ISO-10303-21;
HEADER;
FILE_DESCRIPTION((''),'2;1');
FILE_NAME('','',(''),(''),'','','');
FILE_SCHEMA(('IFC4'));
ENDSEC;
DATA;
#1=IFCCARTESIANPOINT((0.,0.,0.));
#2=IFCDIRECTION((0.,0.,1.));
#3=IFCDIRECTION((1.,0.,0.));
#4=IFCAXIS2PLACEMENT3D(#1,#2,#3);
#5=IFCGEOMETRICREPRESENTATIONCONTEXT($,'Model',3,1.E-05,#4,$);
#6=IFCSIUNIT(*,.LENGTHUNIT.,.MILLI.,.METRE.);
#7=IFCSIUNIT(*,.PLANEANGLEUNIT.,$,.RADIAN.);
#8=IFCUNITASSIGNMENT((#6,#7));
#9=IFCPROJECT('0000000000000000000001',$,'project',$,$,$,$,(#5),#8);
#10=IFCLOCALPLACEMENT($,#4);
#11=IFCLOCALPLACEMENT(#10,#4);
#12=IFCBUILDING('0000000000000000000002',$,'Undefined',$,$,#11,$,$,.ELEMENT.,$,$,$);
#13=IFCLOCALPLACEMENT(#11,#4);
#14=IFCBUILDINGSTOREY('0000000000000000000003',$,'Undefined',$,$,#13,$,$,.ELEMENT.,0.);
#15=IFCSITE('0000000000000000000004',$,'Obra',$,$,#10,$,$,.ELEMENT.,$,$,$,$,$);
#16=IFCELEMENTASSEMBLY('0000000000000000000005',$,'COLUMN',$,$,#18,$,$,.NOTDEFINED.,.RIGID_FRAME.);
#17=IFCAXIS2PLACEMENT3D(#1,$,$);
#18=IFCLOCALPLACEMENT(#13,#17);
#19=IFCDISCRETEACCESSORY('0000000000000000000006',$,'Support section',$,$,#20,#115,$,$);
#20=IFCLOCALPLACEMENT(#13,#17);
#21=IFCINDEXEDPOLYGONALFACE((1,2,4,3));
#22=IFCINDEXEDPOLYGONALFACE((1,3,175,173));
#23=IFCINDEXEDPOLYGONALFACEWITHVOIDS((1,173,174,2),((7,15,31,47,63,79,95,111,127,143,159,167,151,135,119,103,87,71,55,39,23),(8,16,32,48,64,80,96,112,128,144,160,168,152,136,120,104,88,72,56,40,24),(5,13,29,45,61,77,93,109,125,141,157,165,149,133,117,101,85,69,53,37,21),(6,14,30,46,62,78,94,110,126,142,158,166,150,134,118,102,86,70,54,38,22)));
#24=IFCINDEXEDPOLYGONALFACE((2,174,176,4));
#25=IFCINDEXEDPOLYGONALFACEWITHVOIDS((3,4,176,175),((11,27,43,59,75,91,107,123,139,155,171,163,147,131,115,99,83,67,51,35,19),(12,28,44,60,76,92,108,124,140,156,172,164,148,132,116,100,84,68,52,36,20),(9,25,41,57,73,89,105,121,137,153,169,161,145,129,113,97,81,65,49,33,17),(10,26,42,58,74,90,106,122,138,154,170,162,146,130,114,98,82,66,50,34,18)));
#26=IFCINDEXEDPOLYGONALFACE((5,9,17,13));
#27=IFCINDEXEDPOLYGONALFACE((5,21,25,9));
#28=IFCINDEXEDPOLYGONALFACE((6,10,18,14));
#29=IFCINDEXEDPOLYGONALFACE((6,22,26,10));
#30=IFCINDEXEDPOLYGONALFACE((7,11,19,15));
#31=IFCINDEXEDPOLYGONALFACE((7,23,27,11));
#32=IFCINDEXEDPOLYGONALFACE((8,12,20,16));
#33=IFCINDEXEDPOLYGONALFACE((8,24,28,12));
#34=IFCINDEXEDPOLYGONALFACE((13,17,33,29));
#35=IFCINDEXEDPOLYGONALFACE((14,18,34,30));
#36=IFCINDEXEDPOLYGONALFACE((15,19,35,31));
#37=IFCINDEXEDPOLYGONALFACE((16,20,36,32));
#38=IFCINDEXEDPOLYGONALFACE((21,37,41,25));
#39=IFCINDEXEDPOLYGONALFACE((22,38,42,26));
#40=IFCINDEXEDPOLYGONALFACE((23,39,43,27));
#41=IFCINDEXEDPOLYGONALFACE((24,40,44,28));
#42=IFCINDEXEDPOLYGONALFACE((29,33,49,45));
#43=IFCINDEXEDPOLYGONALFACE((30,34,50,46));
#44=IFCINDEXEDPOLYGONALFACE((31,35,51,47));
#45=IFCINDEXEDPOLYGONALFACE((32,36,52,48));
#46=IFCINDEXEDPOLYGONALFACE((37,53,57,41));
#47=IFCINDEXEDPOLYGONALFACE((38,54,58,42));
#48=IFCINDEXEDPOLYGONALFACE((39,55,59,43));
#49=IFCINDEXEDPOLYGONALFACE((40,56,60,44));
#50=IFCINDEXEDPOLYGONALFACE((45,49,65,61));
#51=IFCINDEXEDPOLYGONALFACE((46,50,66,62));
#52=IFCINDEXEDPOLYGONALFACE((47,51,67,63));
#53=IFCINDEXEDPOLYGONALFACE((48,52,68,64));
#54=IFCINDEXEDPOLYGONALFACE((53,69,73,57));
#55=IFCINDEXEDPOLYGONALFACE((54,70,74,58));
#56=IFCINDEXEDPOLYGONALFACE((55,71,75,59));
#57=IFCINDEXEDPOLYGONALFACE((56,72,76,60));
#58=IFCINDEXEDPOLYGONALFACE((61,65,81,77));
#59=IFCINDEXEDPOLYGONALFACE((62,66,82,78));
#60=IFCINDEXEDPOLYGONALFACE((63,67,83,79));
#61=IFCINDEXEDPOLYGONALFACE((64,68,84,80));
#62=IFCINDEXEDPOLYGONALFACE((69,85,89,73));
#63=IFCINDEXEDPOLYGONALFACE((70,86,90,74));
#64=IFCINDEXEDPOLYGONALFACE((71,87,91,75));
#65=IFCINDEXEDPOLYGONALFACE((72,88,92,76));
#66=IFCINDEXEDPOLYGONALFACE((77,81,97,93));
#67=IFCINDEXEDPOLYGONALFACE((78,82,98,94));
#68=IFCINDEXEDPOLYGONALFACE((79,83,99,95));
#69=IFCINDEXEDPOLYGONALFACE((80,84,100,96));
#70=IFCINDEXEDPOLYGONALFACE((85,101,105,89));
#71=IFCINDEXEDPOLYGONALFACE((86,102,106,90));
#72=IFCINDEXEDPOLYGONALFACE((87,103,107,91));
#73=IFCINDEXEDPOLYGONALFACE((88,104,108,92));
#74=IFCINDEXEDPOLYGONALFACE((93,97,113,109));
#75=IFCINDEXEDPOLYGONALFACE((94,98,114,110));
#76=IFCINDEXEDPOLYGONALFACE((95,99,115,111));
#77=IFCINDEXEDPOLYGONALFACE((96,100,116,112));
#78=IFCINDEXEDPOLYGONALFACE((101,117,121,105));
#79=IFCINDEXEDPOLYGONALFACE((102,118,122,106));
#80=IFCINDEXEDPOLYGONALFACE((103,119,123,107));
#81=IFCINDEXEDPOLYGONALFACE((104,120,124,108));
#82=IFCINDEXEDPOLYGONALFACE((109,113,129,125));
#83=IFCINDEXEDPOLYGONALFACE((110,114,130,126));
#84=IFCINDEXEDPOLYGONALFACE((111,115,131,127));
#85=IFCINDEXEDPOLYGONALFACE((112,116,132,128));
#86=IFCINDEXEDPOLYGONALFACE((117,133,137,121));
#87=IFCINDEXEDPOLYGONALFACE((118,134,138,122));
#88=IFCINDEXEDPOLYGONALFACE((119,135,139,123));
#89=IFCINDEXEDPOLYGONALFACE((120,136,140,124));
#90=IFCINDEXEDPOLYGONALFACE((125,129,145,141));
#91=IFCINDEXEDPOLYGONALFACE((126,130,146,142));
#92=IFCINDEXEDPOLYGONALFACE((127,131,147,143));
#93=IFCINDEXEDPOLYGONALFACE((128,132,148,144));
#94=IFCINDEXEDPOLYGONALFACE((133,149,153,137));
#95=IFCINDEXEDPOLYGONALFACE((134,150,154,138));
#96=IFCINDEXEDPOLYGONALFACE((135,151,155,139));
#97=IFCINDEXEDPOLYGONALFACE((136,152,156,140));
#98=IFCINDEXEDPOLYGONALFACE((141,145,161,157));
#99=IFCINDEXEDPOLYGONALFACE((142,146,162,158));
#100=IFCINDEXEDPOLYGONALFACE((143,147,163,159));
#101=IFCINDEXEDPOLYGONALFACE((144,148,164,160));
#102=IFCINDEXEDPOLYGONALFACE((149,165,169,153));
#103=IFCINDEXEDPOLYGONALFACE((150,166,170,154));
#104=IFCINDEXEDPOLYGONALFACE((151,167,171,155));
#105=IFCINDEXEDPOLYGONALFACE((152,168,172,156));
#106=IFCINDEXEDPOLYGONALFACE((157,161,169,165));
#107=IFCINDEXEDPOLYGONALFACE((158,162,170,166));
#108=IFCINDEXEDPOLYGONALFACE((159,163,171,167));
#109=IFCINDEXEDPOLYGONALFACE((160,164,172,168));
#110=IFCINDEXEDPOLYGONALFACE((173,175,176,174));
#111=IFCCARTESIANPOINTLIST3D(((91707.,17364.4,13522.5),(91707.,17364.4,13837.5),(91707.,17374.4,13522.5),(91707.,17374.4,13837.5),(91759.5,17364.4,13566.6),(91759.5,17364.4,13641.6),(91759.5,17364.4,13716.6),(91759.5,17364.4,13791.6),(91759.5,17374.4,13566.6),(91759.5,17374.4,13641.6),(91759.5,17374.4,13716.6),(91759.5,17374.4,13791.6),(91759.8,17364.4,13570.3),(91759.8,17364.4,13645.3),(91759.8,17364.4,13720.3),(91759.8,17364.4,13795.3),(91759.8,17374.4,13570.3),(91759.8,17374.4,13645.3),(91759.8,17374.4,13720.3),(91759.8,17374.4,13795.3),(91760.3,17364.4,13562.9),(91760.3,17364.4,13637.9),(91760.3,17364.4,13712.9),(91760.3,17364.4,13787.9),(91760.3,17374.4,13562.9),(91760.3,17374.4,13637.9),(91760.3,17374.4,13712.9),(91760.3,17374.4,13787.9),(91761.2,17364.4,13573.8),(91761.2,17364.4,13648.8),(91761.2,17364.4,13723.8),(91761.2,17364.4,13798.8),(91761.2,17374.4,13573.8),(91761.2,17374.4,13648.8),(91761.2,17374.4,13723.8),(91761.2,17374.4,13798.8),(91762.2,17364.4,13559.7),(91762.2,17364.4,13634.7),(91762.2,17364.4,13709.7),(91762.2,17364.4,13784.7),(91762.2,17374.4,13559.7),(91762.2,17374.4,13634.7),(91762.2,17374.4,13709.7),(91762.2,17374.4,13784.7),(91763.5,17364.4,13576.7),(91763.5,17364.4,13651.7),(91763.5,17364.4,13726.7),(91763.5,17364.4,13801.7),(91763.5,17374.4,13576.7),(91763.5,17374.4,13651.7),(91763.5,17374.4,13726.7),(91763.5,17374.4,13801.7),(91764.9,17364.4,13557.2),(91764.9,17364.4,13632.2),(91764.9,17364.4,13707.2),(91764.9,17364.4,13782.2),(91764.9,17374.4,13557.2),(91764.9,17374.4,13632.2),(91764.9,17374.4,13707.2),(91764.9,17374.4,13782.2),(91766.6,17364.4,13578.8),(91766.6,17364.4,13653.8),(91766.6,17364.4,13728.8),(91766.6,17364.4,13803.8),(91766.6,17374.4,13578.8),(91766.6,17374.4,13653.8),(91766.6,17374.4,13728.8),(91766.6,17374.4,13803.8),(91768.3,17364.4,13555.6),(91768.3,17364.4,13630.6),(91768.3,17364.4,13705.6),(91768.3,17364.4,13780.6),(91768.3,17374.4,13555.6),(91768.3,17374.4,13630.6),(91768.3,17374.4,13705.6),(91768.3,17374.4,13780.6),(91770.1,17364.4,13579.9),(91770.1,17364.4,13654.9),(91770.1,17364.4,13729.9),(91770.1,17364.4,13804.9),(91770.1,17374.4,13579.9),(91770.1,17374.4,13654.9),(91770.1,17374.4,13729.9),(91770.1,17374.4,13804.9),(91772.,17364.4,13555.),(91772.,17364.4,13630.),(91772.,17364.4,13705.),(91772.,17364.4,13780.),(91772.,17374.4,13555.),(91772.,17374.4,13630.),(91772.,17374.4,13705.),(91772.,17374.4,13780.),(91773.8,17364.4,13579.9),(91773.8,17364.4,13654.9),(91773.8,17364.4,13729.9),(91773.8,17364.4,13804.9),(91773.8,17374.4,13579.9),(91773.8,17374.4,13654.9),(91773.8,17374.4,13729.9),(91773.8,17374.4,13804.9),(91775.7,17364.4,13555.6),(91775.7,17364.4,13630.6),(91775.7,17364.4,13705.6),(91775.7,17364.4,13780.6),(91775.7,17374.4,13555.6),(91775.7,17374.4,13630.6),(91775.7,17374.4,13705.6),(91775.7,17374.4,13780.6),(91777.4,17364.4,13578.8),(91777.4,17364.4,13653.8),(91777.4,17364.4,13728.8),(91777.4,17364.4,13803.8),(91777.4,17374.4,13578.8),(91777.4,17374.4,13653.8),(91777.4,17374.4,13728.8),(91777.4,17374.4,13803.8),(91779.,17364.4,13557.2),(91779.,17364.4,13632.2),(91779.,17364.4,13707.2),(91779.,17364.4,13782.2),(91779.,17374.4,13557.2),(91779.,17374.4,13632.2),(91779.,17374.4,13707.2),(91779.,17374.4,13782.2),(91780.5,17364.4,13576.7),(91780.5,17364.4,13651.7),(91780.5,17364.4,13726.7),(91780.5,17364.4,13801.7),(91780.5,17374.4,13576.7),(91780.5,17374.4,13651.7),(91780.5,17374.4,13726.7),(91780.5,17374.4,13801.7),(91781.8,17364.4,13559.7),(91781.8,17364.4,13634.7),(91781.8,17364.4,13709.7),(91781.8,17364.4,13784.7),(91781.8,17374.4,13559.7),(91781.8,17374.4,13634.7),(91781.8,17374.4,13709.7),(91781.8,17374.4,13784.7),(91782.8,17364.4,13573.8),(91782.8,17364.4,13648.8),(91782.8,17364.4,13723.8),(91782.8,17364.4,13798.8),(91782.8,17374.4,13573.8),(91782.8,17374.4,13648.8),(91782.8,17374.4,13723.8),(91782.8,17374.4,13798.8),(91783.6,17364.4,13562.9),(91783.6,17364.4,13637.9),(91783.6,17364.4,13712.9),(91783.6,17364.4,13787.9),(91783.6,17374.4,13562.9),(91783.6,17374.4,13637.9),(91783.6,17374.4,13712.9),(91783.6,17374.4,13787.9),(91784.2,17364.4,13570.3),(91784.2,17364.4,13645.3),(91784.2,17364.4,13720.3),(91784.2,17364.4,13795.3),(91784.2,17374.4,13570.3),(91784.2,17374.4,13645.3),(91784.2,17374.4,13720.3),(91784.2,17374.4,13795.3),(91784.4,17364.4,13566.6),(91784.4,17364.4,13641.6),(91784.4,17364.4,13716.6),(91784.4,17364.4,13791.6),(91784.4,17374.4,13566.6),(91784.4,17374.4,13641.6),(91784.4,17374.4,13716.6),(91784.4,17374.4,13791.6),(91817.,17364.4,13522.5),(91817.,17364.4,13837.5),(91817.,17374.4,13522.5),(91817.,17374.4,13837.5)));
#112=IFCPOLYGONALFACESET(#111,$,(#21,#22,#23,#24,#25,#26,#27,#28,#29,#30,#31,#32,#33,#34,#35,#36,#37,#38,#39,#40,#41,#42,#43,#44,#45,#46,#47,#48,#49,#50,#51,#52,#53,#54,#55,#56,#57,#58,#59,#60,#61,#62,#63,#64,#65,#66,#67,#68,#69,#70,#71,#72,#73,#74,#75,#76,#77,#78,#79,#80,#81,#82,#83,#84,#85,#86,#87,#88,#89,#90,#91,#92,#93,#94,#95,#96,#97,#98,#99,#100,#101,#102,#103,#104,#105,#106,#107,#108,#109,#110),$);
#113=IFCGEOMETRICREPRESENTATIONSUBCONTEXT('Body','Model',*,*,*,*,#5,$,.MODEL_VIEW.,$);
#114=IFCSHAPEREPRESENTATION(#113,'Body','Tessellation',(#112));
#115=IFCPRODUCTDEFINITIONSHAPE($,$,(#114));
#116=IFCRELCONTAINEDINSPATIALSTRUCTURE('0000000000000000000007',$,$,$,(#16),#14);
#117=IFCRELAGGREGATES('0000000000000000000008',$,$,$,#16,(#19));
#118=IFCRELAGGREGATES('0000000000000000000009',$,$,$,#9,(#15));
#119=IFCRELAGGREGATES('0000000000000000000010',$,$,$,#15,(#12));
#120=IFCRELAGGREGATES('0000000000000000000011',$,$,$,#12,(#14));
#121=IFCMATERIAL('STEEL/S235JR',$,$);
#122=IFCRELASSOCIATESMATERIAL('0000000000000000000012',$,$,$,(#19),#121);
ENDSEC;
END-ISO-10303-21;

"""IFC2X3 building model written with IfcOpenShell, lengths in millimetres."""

from ifc_helpers import new_model, si_unit, frame, origin_with_axes, origin_2d_with_axis, place, context, subcontext, project, spatial, rectangle, circle, extrude, source, transform, mapped, material, element, aggregate, save


model = new_model("IFC2X3")

# Units and contexts
model_context = context("Model", 3, precision=1e-05, world=origin_with_axes())
body_context = subcontext(model_context, "Body", "Model", "MODEL_VIEW")
ifc_project = project(units=[si_unit("LENGTHUNIT", "METRE", prefix="MILLI"), si_unit("PLANEANGLEUNIT", "RADIAN")], contexts=[model_context])

# Site, building, storey
site_placement = place(None, origin_with_axes())
site = spatial("IfcSite", under=ifc_project, at=site_placement, Name="Obra", CompositionType="ELEMENT")
building_placement = place(site_placement, origin_with_axes())
building = spatial("IfcBuilding", under=site, at=building_placement, Name="Undefined", CompositionType="ELEMENT")
storey_placement = place(building_placement, origin_with_axes())
storey = spatial("IfcBuildingStorey", under=building, at=storey_placement, Name="Undefined", CompositionType="ELEMENT", Elevation=0.0)

# Element assembly
assembly_1_placement = place(storey_placement, origin_with_axes())
assembly_1 = element("IfcElementAssembly", 1, at=assembly_1_placement, inside=storey, Name="COLUMN", AssemblyPlace="NOTDEFINED", PredefinedType="RIGID_FRAME")
ifc_material_1 = material(Name="STEEL/S235JR")

# Discrete accessory, opening
discrete_accessory_1_placement = place(assembly_1_placement, frame((91762.0, 17369.4, 13522.5), z_axis=(0.0, 0.0, 1.0), x_axis=(-1.0, 0.0, 0.0)))
discrete_accessory_1 = element("IfcDiscreteAccessory", 2, at=discrete_accessory_1_placement, material=ifc_material_1, Name="Support section", context=body_context, shape_type="SweptSolid", body=[
    extrude(rectangle(XDim=10.0, YDim=110.0, at=origin_2d_with_axis()), frame((0.0, 0.0, 315.0), z_axis=(0.0, 0.0, -1.0), x_axis=(0.0, 1.0, 0.0)), (0.0, 0.0, 1.0), 315.0),
])
shared_shape_1 = source(origin_with_axes(), body_context, "Body", "SweptSolid", [
    extrude(circle(Radius=12.5, at=origin_2d_with_axis()), frame((0.0, -15.8, 0.0), z_axis=(0.0, 1.0, 0.0), x_axis=(1.0, 0.0, 0.0)), (0.0, 0.0, 1.0), 10.2),
])
opening_1_placement = place(assembly_1_placement, frame((91727.0, 17380.1, 13900.0), z_axis=(1.0, 0.0, 0.0), x_axis=(0.0, 0.0, -1.0)))
element("IfcOpeningElement", 3, at=opening_1_placement, cuts=discrete_accessory_1, ObjectType="Opening", context=body_context, shape_type="MappedRepresentation", body=[
    mapped(shared_shape_1, transform((107.5, 0.0, 45.0))),
    mapped(shared_shape_1, transform((182.5, 0.0, 45.0))),
    mapped(shared_shape_1, transform((257.5, 0.0, 45.0))),
    mapped(shared_shape_1, transform((332.5, 0.0, 45.0))),
])
aggregate(assembly_1, [discrete_accessory_1])

save(model, "model.ifc")
